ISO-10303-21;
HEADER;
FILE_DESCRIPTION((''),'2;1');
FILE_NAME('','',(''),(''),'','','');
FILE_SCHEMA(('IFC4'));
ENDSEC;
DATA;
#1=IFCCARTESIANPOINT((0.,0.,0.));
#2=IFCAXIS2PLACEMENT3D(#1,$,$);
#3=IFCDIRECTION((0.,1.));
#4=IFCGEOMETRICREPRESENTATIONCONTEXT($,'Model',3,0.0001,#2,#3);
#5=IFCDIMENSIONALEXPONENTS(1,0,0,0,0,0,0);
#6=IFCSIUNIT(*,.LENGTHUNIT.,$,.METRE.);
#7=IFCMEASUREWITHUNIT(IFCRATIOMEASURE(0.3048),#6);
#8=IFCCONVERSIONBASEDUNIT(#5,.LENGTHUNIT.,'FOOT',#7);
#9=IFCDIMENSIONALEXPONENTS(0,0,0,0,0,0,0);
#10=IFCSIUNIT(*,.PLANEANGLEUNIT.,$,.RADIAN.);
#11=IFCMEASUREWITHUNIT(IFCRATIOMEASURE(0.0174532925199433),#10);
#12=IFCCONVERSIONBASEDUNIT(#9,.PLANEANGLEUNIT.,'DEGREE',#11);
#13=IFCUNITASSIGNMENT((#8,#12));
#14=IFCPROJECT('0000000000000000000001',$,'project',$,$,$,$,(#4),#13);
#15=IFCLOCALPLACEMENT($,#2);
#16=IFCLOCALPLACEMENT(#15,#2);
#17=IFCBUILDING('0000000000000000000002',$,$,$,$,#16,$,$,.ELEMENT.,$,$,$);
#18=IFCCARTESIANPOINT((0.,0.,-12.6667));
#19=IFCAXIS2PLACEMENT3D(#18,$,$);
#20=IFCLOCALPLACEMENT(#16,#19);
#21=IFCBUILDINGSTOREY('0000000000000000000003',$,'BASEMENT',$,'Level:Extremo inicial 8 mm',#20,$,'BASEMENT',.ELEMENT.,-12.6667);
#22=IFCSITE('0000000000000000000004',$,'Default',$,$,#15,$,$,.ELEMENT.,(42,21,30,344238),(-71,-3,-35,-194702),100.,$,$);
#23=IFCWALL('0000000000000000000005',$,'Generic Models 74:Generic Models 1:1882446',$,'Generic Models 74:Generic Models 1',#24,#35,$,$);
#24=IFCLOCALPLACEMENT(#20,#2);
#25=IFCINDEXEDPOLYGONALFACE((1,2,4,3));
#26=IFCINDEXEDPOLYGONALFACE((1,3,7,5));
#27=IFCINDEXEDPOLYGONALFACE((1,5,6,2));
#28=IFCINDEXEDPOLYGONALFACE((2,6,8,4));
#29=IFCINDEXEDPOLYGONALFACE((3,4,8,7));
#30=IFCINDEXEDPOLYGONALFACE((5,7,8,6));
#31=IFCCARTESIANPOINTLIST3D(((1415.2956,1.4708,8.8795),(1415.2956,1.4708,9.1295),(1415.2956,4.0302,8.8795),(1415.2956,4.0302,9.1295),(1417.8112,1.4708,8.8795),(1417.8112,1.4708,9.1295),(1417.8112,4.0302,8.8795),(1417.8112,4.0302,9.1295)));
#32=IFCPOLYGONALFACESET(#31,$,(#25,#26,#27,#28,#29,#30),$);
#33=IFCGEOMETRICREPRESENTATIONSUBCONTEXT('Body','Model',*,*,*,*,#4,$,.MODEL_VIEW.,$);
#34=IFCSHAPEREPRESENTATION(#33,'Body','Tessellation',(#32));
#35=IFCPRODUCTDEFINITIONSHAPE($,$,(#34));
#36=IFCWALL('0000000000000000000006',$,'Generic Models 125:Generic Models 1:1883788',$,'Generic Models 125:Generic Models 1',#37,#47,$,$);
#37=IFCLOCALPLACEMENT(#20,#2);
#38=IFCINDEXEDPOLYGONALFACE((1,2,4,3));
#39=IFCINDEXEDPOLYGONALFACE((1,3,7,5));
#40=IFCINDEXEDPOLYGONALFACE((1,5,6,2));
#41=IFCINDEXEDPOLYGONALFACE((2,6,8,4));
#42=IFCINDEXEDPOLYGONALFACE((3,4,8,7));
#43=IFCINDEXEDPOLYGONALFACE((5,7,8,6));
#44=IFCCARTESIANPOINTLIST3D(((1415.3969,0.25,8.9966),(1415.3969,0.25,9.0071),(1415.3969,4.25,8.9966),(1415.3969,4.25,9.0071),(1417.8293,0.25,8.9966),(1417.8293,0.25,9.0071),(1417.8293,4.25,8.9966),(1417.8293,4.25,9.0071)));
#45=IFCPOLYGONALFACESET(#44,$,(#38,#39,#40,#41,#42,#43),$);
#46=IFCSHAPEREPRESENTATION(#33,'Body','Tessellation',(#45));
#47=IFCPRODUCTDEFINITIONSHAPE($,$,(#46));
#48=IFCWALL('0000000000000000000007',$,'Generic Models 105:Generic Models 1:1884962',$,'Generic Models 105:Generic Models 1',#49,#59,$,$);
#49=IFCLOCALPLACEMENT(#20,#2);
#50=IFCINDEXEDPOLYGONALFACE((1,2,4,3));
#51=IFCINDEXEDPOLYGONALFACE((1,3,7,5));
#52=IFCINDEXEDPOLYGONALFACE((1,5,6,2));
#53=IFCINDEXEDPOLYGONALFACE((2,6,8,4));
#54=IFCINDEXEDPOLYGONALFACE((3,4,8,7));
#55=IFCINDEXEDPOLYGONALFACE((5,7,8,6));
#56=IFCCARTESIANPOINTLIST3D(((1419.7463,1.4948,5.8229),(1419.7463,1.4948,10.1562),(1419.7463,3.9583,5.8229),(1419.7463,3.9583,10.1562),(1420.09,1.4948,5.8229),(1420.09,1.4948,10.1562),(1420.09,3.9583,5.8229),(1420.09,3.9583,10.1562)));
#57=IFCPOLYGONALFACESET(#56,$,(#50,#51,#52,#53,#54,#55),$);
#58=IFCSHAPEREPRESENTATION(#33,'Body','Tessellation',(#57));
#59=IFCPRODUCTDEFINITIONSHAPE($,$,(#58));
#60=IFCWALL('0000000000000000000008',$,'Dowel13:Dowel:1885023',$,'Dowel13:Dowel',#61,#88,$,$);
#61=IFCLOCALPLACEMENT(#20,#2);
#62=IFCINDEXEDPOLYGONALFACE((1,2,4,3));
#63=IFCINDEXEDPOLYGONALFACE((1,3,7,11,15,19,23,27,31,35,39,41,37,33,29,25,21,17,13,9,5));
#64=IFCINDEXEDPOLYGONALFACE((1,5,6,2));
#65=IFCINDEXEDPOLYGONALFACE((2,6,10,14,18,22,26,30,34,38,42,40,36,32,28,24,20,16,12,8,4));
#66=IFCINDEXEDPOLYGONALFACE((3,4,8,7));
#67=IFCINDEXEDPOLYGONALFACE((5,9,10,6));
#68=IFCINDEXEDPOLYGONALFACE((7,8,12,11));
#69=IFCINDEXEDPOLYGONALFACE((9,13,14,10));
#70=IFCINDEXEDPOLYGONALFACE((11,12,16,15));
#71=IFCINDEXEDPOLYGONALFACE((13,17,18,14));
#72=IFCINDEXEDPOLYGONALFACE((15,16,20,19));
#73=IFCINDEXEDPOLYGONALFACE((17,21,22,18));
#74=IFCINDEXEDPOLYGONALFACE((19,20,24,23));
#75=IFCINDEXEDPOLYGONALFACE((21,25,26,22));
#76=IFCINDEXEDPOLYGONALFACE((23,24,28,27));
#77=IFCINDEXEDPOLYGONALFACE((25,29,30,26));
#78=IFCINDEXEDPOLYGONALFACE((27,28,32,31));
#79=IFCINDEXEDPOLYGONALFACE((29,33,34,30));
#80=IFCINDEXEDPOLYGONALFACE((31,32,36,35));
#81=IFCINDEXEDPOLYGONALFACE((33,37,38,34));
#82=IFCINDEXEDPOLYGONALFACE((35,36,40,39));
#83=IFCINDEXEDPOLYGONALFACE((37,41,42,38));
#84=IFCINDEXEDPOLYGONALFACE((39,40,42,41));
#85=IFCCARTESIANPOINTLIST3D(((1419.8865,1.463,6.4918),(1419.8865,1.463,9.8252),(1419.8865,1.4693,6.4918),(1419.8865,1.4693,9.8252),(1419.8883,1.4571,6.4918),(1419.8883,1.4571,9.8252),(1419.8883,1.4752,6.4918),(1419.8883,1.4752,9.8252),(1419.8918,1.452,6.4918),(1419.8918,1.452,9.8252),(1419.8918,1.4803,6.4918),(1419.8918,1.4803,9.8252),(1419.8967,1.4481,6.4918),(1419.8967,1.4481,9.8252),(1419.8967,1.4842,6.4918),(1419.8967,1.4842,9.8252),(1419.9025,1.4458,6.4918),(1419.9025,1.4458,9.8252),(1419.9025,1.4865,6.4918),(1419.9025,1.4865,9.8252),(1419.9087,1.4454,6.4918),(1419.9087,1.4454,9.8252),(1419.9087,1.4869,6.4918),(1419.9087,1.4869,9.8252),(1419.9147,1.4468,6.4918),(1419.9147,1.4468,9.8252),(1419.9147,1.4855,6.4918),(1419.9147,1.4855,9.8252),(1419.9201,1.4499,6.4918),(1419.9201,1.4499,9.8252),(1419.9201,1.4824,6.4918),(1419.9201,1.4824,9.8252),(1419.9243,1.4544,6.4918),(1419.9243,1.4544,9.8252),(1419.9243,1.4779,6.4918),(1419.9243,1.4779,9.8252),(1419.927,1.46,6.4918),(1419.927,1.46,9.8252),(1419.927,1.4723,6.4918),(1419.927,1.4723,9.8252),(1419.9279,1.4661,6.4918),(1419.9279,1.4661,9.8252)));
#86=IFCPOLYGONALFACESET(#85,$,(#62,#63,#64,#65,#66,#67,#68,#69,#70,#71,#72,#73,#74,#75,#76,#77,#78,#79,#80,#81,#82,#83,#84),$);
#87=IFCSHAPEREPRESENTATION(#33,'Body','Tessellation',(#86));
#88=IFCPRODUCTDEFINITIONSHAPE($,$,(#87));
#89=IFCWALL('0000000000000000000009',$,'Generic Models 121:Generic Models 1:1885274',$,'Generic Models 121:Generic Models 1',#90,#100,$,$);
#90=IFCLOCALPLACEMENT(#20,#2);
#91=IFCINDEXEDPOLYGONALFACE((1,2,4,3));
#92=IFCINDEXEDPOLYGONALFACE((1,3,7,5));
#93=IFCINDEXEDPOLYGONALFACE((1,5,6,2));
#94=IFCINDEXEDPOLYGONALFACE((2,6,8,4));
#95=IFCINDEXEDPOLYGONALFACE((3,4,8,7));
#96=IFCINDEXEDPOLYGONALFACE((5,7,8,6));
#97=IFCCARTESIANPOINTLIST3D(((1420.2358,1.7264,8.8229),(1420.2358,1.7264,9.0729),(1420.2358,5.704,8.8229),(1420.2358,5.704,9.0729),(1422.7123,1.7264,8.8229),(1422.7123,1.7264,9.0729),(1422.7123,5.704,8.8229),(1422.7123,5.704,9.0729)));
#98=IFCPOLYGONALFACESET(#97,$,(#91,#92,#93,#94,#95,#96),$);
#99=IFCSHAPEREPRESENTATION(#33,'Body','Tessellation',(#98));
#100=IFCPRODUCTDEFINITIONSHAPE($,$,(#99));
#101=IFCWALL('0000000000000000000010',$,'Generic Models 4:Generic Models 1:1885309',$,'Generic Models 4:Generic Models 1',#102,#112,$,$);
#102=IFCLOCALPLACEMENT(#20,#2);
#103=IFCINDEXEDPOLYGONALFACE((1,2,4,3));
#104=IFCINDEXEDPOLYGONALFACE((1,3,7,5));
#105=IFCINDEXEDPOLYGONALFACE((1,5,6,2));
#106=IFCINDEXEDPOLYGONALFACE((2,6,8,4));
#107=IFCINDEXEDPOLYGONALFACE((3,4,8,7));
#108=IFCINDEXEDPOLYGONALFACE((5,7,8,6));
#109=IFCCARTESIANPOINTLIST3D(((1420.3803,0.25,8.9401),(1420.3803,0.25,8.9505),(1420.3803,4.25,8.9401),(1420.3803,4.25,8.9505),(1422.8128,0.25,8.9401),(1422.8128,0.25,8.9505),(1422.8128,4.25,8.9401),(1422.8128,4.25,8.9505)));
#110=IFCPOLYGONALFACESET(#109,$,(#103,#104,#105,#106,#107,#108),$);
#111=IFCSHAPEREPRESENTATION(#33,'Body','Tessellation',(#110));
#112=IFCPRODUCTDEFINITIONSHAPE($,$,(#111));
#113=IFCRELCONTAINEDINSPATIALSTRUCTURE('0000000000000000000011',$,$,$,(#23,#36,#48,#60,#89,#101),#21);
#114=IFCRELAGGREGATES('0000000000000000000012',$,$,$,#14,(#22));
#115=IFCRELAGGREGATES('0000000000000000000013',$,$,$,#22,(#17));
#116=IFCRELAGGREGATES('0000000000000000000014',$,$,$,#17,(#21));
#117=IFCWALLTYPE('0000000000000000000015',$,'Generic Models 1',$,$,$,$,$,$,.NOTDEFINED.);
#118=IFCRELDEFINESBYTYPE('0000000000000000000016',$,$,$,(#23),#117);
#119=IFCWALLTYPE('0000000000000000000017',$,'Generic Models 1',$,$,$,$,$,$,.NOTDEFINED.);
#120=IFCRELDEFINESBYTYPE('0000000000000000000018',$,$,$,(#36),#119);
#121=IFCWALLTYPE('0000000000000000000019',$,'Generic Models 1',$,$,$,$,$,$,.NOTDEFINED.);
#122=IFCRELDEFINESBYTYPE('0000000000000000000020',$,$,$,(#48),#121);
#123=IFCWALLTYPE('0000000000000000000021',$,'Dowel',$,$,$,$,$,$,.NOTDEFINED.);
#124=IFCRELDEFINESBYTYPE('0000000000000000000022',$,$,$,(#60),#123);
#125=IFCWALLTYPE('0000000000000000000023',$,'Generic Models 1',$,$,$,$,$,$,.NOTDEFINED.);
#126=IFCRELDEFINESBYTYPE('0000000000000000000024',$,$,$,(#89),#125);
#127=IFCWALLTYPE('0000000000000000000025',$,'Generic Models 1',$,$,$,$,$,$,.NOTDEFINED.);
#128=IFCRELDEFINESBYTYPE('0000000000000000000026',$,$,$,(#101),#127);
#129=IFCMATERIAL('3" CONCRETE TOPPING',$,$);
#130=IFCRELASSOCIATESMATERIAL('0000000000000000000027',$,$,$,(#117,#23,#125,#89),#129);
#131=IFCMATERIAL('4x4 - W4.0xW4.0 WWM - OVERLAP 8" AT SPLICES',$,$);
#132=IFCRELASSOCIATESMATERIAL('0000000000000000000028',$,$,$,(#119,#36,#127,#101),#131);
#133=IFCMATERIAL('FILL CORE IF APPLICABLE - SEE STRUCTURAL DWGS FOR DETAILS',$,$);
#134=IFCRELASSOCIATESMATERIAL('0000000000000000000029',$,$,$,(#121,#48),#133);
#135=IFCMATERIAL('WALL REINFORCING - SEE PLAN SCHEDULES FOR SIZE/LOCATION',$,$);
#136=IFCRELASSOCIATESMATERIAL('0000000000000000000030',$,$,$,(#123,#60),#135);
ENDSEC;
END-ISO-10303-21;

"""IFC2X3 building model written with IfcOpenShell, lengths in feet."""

from ifc_helpers import new_model, entity, si_unit, converted_unit, direction, frame, frame_2d, origin, origin_2d_with_axis, place, context, subcontext, project, spatial, rectangle, circle, extrude, material, type_object, element, save


model = new_model("IFC2X3")

# Units and contexts
model_context = context("Model", 3, precision=0.0001, world=origin(), true_north=direction((0.0, 1.0)))
body_context = subcontext(model_context, "Body", "Model", "MODEL_VIEW")
ifc_project = project(units=[converted_unit("LENGTHUNIT", "FOOT", entity("IfcRatioMeasure", 0.3048), si_unit("LENGTHUNIT", "METRE"), dimensions=[1, 0, 0, 0, 0, 0, 0]), converted_unit("PLANEANGLEUNIT", "DEGREE", entity("IfcRatioMeasure", 0.0174532925199433), si_unit("PLANEANGLEUNIT", "RADIAN"), dimensions=[0, 0, 0, 0, 0, 0, 0])], contexts=[model_context])

# Site, building, storey
site_placement = place(None, origin())
site = spatial("IfcSite", under=ifc_project, at=site_placement, Name="Default", CompositionType="ELEMENT", RefLatitude=(42, 21, 30, 344238), RefLongitude=(-71, -3, -35, -194702), RefElevation=100.0)
building_placement = place(site_placement, origin())
building = spatial("IfcBuilding", under=site, at=building_placement, CompositionType="ELEMENT")
storey_placement = place(building_placement, frame((0.0, 0.0, -12.6667)))
storey = spatial("IfcBuildingStorey", under=building, at=storey_placement, Name="BASEMENT", ObjectType="Level:Extremo inicial 8 mm", LongName="BASEMENT", CompositionType="ELEMENT", Elevation=-12.6667)

# Walls
ifc_material_1 = material(Name="3\" CONCRETE TOPPING")
wall_type_1 = type_object("IfcWallType", Name="Generic Models 1", PredefinedType="NOTDEFINED", material=ifc_material_1)
wall_1_placement = place(storey_placement, frame((1415.2956, 1.4708, 8.8795), z_axis=(0.0, 0.0, 1.0), x_axis=(0.0, 1.0, 0.0)))
element("IfcWall", 1, at=wall_1_placement, inside=storey, type_object=wall_type_1, material=ifc_material_1, Name="Generic Models 74:Generic Models 1:1882446", ObjectType="Generic Models 74:Generic Models 1", context=body_context, shape_type="SweptSolid", body=[
    extrude(rectangle(XDim=2.5594, YDim=2.5156, at=frame_2d((0.0, 0.0), x_axis=(1.0, 0.0))), frame((1.2797, -1.2578, 0.0)), (0.0, 0.0, 1.0), 0.25),
])
ifc_material_2 = material(Name="4x4 - W4.0xW4.0 WWM - OVERLAP 8\" AT SPLICES")
wall_type_2 = type_object("IfcWallType", Name="Generic Models 1", PredefinedType="NOTDEFINED", material=ifc_material_2)
wall_2_placement = place(storey_placement, frame((1415.3969, 0.25, 8.9966), z_axis=(0.0, 0.0, 1.0), x_axis=(0.0, 1.0, 0.0)))
element("IfcWall", 2, at=wall_2_placement, inside=storey, type_object=wall_type_2, material=ifc_material_2, Name="Generic Models 125:Generic Models 1:1883788", ObjectType="Generic Models 125:Generic Models 1", context=body_context, shape_type="SweptSolid", body=[
    extrude(rectangle(XDim=4.0, YDim=2.4325, at=frame_2d((0.0, 0.0), x_axis=(1.0, 0.0))), frame((2.0, -1.2162, 0.0)), (0.0, 0.0, 1.0), 0.0104),
])
ifc_material_3 = material(Name="FILL CORE IF APPLICABLE - SEE STRUCTURAL DWGS FOR DETAILS")
wall_type_3 = type_object("IfcWallType", Name="Generic Models 1", PredefinedType="NOTDEFINED", material=ifc_material_3)
wall_3_placement = place(storey_placement, frame((1419.7463, 1.4948, 5.8229), z_axis=(0.0, 0.0, 1.0), x_axis=(0.0, 1.0, 0.0)))
element("IfcWall", 3, at=wall_3_placement, inside=storey, type_object=wall_type_3, material=ifc_material_3, Name="Generic Models 105:Generic Models 1:1884962", ObjectType="Generic Models 105:Generic Models 1", context=body_context, shape_type="SweptSolid", body=[
    extrude(rectangle(XDim=2.4635, YDim=0.3438, at=frame_2d((0.0, 0.0), x_axis=(1.0, 0.0))), frame((1.2318, -0.1719, 0.0)), (0.0, 0.0, 1.0), 4.3333),
])

# Wall
ifc_material_4 = material(Name="WALL REINFORCING - SEE PLAN SCHEDULES FOR SIZE/LOCATION")
wall_type_4 = type_object("IfcWallType", Name="Dowel", PredefinedType="NOTDEFINED", material=ifc_material_4)
wall_4_placement = place(storey_placement, frame((1419.8863, 1.4453, 6.4918), z_axis=(0.0, 0.0, 1.0), x_axis=(0.0, 1.0, 0.0)))
element("IfcWall", 4, at=wall_4_placement, inside=storey, type_object=wall_type_4, material=ifc_material_4, Name="Dowel13:Dowel:1885023", ObjectType="Dowel13:Dowel", context=body_context, shape_type="SweptSolid", body=[
    extrude(circle(Radius=0.0208, at=origin_2d_with_axis()), frame((0.0208, -0.0208, 0.0), z_axis=(0.0, 0.0, 1.0), x_axis=(0.0, -1.0, 0.0)), (0.0, 0.0, 1.0), 3.3333),
])

# Walls
wall_type_5 = type_object("IfcWallType", Name="Generic Models 1", PredefinedType="NOTDEFINED", material=ifc_material_1)
wall_5_placement = place(storey_placement, frame((1420.2358, 1.7264, 8.8229), z_axis=(0.0, 0.0, 1.0), x_axis=(0.0, 1.0, 0.0)))
element("IfcWall", 5, at=wall_5_placement, inside=storey, type_object=wall_type_5, material=ifc_material_1, Name="Generic Models 121:Generic Models 1:1885274", ObjectType="Generic Models 121:Generic Models 1", context=body_context, shape_type="SweptSolid", body=[
    extrude(rectangle(XDim=3.9776, YDim=2.4764, at=frame_2d((0.0, 0.0), x_axis=(1.0, 0.0))), frame((1.9888, -1.2382, 0.0)), (0.0, 0.0, 1.0), 0.25),
])
wall_type_6 = type_object("IfcWallType", Name="Generic Models 1", PredefinedType="NOTDEFINED", material=ifc_material_2)
wall_6_placement = place(storey_placement, frame((1420.3803, 0.25, 8.9401), z_axis=(0.0, 0.0, 1.0), x_axis=(0.0, 1.0, 0.0)))
element("IfcWall", 6, at=wall_6_placement, inside=storey, type_object=wall_type_6, material=ifc_material_2, Name="Generic Models 4:Generic Models 1:1885309", ObjectType="Generic Models 4:Generic Models 1", context=body_context, shape_type="SweptSolid", body=[
    extrude(rectangle(XDim=4.0, YDim=2.4325, at=frame_2d((0.0, 0.0), x_axis=(1.0, 0.0))), frame((2.0, -1.2162, 0.0)), (0.0, 0.0, 1.0), 0.0104),
])

save(model, "model.ifc")
